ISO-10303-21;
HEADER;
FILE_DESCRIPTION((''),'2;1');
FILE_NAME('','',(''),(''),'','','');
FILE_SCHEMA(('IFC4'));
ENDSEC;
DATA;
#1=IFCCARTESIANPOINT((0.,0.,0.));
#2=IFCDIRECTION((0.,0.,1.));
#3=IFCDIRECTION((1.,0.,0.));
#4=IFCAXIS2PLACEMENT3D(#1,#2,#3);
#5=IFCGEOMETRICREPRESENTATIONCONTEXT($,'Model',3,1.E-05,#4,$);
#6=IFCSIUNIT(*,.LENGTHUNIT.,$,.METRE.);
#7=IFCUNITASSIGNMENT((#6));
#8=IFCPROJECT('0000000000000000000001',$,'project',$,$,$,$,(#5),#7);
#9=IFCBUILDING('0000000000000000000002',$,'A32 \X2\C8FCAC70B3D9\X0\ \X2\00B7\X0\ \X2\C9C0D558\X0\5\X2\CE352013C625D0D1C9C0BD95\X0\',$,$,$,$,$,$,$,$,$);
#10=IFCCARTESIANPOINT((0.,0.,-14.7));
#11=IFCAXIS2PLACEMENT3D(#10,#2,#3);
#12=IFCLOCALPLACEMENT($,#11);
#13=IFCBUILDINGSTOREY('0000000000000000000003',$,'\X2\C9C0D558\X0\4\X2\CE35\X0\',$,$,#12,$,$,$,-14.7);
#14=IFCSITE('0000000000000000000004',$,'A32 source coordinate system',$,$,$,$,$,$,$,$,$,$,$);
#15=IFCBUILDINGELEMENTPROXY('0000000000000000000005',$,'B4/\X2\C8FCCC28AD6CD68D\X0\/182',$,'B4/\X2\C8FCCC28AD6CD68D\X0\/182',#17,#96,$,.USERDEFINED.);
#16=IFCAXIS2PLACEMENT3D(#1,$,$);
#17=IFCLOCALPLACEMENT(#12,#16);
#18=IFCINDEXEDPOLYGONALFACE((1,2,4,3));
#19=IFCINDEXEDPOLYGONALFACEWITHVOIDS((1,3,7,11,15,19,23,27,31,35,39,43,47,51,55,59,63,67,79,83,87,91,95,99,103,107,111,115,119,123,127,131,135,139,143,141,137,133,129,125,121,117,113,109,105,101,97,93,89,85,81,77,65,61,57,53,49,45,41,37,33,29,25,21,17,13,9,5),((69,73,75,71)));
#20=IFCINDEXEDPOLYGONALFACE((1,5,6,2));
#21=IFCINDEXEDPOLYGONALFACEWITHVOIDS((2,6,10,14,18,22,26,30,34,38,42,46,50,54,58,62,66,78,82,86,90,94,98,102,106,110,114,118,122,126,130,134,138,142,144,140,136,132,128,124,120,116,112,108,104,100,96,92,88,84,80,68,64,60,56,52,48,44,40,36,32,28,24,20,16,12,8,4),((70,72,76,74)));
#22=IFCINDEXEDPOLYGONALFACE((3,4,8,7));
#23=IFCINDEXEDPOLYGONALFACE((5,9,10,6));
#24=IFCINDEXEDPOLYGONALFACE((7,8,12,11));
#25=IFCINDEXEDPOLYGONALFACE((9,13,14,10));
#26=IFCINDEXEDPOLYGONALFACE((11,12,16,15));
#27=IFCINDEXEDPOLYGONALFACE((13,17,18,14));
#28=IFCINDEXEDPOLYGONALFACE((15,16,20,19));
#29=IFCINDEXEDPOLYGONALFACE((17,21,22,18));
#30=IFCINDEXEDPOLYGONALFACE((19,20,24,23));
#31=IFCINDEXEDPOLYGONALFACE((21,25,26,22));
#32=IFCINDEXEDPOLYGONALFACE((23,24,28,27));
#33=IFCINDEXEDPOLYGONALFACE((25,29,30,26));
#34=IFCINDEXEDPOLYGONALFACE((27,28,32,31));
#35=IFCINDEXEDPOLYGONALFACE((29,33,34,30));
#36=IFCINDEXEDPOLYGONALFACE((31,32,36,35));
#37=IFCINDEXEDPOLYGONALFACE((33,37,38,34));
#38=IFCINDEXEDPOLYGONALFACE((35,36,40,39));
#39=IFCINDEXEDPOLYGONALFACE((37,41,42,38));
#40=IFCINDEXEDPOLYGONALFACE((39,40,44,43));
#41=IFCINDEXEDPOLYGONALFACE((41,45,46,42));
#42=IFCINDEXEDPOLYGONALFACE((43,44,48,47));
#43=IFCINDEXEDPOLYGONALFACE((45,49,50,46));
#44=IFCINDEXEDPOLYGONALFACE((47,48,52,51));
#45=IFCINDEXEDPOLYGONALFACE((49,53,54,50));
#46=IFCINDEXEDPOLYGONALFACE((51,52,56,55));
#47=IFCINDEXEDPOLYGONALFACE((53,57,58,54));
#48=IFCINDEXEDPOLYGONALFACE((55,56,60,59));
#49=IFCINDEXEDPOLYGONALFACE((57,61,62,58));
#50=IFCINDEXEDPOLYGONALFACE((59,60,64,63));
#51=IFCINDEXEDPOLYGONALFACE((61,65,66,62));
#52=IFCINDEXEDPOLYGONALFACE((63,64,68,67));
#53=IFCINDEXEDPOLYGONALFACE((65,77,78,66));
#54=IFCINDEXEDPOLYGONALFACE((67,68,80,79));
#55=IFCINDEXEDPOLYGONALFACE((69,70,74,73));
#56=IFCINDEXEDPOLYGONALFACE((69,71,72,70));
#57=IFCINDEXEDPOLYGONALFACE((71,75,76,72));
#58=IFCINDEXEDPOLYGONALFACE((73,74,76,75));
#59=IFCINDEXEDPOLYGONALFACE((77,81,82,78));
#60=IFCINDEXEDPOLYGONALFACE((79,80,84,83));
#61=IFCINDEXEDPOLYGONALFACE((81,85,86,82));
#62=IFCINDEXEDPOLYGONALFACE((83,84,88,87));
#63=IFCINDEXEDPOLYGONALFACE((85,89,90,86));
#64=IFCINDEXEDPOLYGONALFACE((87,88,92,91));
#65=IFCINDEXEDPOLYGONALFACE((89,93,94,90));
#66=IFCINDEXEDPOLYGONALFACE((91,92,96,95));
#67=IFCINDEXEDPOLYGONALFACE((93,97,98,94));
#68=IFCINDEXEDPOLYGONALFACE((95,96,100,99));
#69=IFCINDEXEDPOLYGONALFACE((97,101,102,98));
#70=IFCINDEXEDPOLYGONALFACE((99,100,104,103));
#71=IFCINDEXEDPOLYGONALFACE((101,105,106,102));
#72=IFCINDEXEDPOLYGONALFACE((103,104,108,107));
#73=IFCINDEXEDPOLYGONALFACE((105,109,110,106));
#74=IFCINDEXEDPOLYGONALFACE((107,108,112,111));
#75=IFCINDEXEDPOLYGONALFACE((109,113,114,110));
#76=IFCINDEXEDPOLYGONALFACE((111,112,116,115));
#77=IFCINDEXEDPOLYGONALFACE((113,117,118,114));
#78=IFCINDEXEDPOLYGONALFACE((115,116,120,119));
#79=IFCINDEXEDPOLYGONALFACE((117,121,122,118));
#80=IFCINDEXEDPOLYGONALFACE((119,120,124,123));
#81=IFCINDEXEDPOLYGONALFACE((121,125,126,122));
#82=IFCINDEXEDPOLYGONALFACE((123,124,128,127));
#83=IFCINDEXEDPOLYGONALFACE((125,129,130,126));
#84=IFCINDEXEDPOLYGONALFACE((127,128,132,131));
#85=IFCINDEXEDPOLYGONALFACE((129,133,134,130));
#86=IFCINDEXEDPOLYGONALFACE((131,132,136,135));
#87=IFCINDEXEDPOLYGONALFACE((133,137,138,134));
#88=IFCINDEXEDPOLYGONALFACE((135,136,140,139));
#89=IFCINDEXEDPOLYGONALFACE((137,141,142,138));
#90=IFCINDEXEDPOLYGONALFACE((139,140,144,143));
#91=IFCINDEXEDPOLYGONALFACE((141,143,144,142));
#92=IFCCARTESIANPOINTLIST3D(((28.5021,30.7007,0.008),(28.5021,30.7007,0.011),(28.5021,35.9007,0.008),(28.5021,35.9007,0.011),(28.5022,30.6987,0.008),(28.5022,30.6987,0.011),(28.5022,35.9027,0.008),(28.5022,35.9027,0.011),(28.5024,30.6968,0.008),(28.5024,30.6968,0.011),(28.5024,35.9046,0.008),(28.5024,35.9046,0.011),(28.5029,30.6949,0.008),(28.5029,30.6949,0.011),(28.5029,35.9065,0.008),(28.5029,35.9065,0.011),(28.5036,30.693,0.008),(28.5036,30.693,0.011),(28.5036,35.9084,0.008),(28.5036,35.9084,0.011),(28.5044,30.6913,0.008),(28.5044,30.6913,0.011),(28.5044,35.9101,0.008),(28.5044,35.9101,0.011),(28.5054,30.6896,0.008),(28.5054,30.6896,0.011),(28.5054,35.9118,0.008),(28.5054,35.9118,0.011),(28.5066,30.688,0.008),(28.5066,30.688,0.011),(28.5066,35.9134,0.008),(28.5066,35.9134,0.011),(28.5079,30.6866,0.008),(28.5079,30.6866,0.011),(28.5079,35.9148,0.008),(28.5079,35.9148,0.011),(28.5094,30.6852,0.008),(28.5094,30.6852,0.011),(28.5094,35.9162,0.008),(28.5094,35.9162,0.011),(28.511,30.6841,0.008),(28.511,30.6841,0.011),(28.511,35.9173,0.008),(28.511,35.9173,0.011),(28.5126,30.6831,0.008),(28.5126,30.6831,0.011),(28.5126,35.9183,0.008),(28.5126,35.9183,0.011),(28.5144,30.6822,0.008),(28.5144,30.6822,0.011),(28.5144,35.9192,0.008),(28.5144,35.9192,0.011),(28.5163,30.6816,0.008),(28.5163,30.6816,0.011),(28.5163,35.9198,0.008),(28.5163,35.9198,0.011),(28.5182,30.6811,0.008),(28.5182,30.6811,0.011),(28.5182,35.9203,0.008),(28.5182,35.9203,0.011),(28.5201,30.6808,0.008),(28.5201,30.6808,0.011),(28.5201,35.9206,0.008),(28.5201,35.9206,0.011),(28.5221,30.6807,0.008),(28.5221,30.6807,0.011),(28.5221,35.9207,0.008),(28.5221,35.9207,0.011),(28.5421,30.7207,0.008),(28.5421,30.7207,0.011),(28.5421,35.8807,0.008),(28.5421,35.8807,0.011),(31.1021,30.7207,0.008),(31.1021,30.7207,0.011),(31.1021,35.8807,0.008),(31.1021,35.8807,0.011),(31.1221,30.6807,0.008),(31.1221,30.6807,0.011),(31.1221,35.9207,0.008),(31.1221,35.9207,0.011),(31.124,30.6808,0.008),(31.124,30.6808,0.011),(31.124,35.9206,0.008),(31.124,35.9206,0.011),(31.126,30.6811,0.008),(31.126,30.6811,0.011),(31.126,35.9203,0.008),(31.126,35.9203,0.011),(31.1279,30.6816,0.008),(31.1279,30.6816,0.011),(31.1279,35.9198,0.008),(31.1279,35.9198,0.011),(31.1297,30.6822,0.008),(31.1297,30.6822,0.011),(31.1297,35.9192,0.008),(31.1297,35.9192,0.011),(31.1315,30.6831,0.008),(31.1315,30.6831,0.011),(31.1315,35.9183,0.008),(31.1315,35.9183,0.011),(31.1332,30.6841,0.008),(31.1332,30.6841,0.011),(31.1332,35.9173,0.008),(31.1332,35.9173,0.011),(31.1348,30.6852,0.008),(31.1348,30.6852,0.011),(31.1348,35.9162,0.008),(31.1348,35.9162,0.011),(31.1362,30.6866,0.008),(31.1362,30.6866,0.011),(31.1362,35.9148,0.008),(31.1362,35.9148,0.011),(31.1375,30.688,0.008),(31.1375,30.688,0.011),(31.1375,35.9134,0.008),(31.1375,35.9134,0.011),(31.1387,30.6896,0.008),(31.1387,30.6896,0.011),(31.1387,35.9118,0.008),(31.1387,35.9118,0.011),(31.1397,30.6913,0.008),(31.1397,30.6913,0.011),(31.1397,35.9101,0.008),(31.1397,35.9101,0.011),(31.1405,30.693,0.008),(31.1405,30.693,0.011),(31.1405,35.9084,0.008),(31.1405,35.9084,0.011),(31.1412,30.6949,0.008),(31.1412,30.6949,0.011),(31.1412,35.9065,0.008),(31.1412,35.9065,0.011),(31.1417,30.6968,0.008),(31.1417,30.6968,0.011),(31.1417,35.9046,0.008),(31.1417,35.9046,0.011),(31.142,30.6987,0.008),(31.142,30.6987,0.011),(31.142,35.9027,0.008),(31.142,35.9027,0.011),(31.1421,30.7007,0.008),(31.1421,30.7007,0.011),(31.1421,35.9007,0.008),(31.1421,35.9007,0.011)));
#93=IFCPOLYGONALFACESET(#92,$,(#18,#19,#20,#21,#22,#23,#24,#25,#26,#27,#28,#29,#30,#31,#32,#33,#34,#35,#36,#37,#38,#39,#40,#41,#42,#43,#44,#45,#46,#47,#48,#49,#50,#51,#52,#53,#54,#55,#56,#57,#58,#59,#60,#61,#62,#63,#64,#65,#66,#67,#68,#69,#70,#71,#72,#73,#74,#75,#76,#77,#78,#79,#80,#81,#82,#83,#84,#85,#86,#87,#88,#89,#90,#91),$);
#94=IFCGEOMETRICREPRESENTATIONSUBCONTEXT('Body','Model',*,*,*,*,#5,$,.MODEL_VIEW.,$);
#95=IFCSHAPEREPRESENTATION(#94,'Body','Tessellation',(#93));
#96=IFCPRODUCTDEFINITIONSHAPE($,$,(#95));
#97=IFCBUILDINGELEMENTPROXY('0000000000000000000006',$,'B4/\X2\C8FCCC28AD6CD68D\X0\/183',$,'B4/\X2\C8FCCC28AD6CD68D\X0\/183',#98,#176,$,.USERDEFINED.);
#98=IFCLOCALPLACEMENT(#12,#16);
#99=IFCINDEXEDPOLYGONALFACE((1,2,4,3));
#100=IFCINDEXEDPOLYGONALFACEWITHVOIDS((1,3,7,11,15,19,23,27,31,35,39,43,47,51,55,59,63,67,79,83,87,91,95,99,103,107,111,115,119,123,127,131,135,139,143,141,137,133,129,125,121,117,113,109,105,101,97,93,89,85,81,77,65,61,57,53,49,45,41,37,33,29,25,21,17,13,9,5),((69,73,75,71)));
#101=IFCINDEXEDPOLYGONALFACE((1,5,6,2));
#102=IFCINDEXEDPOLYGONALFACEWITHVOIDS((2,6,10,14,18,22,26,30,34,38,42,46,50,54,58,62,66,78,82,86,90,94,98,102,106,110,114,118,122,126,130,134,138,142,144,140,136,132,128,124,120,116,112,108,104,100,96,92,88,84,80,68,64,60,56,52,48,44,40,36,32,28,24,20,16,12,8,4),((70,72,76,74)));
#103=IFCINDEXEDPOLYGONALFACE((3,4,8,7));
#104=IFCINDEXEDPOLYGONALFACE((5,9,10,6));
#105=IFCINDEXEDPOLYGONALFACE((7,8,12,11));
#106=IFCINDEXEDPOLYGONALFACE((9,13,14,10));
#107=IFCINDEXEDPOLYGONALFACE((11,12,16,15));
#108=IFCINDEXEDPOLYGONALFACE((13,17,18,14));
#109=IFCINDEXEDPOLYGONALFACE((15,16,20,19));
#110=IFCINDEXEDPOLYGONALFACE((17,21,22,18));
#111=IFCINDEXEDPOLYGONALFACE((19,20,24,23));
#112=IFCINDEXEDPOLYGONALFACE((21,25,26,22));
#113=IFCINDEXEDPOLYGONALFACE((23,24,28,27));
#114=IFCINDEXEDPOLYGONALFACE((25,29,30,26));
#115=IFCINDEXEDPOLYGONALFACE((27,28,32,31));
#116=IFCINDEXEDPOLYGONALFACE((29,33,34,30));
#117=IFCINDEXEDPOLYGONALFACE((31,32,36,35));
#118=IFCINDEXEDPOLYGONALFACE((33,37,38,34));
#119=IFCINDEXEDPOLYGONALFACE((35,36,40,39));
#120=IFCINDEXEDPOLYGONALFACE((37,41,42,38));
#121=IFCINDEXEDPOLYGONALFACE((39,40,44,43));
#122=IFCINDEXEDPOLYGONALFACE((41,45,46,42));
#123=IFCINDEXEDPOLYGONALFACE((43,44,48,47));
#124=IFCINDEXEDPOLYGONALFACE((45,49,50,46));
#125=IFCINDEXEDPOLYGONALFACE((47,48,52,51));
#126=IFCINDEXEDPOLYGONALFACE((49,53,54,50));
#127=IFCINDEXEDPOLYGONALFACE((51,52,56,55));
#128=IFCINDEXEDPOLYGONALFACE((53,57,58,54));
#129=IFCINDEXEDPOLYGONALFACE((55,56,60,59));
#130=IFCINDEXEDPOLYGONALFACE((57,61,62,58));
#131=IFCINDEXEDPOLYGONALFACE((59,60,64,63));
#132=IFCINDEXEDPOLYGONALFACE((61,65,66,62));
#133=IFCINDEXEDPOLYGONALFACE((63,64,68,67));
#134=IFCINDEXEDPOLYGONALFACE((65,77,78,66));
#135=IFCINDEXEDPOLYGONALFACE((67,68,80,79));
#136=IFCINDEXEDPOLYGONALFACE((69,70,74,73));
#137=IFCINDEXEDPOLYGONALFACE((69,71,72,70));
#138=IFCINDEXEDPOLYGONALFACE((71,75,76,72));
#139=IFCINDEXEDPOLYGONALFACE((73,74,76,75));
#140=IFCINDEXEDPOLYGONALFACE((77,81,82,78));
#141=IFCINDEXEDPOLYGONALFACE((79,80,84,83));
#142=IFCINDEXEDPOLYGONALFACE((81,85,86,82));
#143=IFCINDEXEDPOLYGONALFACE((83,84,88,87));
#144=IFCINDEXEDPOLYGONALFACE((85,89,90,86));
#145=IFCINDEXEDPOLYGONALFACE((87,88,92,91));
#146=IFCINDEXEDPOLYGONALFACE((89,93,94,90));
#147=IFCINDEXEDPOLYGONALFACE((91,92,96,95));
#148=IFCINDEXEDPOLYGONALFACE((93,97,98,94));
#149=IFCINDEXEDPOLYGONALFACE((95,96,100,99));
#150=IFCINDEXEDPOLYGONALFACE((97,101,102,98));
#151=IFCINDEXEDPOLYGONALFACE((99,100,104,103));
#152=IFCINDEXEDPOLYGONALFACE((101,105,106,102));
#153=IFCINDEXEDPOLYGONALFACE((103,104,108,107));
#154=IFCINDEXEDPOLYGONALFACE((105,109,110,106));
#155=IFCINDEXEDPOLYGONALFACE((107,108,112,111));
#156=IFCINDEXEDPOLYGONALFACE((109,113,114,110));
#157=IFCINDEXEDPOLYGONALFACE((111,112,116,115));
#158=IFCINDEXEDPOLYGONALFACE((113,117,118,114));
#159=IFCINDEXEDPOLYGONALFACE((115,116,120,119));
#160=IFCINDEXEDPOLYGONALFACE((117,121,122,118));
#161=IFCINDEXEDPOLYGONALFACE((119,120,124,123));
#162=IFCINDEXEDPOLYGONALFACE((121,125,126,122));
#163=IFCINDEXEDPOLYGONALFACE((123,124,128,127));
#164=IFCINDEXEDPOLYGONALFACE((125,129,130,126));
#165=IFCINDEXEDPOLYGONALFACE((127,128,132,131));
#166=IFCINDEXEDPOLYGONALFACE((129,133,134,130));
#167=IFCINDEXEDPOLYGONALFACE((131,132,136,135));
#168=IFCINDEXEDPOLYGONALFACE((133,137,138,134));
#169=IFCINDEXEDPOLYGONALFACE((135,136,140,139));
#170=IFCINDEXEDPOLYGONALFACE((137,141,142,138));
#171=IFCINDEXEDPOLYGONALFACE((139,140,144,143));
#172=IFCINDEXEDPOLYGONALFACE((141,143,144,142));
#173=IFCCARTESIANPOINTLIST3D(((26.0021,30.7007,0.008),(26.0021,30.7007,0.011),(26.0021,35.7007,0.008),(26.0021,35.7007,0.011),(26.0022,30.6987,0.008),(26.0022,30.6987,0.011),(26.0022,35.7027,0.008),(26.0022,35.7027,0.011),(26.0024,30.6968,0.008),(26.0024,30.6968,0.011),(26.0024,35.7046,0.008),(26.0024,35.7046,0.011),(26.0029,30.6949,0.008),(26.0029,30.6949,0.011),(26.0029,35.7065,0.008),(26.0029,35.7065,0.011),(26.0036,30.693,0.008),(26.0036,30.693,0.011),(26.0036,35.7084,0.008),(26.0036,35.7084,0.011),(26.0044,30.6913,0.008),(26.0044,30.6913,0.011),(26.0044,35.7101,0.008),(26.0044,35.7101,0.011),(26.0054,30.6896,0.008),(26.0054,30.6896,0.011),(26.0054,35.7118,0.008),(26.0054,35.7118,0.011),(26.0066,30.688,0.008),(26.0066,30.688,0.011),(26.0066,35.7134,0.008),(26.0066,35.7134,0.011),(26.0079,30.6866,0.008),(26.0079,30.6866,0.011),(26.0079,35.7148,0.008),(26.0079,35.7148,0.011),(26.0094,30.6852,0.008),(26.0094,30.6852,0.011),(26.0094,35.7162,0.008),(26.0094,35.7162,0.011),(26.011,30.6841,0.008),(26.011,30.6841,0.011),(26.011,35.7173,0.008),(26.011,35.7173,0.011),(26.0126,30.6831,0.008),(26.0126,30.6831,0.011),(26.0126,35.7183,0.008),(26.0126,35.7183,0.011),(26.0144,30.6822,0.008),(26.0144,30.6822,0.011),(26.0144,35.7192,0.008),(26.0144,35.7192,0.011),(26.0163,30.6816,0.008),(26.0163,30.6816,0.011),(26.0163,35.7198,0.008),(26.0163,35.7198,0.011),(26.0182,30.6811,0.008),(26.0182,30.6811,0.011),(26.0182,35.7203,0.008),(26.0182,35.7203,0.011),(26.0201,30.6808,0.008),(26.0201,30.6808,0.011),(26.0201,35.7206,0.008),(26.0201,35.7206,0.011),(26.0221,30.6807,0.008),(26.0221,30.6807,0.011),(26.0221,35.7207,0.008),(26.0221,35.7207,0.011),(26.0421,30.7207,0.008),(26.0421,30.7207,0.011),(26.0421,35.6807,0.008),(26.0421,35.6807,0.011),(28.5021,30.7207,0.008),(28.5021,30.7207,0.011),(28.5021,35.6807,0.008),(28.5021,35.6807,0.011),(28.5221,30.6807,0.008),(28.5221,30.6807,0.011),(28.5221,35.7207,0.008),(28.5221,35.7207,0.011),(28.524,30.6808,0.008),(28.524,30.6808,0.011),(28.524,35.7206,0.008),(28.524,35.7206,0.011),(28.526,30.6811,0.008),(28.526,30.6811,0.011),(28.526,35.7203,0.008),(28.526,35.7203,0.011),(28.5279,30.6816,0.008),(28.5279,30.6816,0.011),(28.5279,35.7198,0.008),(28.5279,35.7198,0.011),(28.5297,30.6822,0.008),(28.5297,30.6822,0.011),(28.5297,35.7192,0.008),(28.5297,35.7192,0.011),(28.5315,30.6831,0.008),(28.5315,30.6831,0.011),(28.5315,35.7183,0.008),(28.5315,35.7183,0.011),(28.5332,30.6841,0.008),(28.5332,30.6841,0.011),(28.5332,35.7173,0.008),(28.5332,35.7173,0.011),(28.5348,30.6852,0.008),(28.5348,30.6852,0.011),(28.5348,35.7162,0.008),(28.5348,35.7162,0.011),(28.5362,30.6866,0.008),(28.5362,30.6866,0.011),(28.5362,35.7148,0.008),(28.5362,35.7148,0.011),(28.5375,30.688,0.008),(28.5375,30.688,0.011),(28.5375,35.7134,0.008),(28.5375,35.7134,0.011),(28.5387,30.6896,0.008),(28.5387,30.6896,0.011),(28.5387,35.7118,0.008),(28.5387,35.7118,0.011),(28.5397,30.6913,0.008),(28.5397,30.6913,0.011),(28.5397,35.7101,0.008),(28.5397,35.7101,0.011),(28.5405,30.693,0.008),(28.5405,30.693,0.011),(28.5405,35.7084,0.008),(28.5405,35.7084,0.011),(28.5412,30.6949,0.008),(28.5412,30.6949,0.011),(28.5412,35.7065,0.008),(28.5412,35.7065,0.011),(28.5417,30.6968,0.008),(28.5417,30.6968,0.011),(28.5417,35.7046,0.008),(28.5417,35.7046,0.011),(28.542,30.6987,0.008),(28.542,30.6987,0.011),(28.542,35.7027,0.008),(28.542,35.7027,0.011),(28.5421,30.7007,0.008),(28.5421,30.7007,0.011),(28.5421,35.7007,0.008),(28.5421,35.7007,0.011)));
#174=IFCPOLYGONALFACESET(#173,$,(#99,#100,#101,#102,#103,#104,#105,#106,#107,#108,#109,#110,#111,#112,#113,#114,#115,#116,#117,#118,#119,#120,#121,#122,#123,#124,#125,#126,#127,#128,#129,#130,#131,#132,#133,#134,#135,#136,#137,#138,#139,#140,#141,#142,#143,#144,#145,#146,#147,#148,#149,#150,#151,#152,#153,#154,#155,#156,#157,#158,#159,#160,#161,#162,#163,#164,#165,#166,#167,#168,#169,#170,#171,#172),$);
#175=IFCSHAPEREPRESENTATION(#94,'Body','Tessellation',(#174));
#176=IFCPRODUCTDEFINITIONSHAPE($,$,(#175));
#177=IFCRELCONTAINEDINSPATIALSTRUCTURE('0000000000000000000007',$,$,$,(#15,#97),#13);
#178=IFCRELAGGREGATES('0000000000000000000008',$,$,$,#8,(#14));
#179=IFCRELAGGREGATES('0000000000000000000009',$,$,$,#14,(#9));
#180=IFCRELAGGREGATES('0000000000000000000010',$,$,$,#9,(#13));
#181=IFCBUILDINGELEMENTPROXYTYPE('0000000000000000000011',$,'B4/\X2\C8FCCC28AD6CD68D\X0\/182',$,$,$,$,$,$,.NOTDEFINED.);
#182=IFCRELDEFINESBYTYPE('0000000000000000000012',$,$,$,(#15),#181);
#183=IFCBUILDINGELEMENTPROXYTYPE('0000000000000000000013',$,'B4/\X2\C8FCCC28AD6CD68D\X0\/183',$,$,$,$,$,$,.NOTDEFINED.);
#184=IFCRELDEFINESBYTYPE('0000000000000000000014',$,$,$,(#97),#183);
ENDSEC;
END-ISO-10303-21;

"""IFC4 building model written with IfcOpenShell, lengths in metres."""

from ifc_helpers import new_model, si_unit, frame, origin, origin_with_axes, place, context, subcontext, project, spatial, polyline, outline, extrude, source, transform, mapped, type_object, type_shapes, element, save


model = new_model("IFC4")

# Units and contexts
model_context = context("Model", 3, precision=1e-05, world=origin_with_axes())
body_context = subcontext(model_context, "Body", "Model", "MODEL_VIEW")
ifc_project = project(units=[si_unit("LENGTHUNIT", "METRE")], contexts=[model_context])

# Site, building, storey
site = spatial("IfcSite", under=ifc_project, Name="A32 source coordinate system")
building = spatial("IfcBuilding", under=site, Name="A32 주거동 · 지하5층–옥탑지붕")
storey_placement = place(None, frame((0.0, 0.0, -14.7), z_axis=(0.0, 0.0, 1.0), x_axis=(1.0, 0.0, 0.0)))
storey = spatial("IfcBuildingStorey", under=building, at=storey_placement, Name="지하4층", Elevation=-14.7)

# Building element proxies
building_element_proxy_type_1 = type_object("IfcBuildingElementProxyType", Name="B4/주차구획/182", PredefinedType="NOTDEFINED")
shared_shape_1 = source(origin(), body_context, "Body", "SweptSolid", [
    extrude(outline(polyline([(28.5021, 35.9007), (28.5022, 35.9027), (28.5024, 35.9046), (28.5029, 35.9065), (28.5036, 35.9084), (28.5044, 35.9101), (28.5054, 35.9118), (28.5066, 35.9134), (28.5079, 35.9148), (28.5094, 35.9162), (28.511, 35.9173), (28.5126, 35.9183), (28.5144, 35.9192), (28.5163, 35.9198), (28.5182, 35.9203), (28.5201, 35.9206), (28.5221, 35.9207), (31.1221, 35.9207), (31.124, 35.9206), (31.126, 35.9203), (31.1279, 35.9198), (31.1297, 35.9192), (31.1315, 35.9183), (31.1332, 35.9173), (31.1348, 35.9162), (31.1362, 35.9148), (31.1375, 35.9134), (31.1387, 35.9118), (31.1397, 35.9101), (31.1405, 35.9084), (31.1412, 35.9065), (31.1417, 35.9046), (31.142, 35.9027), (31.1421, 35.9007), (31.1421, 30.7007), (31.142, 30.6987), (31.1417, 30.6968), (31.1412, 30.6949), (31.1405, 30.693), (31.1397, 30.6913), (31.1387, 30.6896), (31.1375, 30.688), (31.1362, 30.6866), (31.1348, 30.6852), (31.1332, 30.6841), (31.1315, 30.6831), (31.1297, 30.6822), (31.1279, 30.6816), (31.126, 30.6811), (31.124, 30.6808), (31.1221, 30.6807), (28.5221, 30.6807), (28.5201, 30.6808), (28.5182, 30.6811), (28.5163, 30.6816), (28.5144, 30.6822), (28.5126, 30.6831), (28.511, 30.6841), (28.5094, 30.6852), (28.5079, 30.6866), (28.5066, 30.688), (28.5054, 30.6896), (28.5044, 30.6913), (28.5036, 30.693), (28.5029, 30.6949), (28.5024, 30.6968), (28.5022, 30.6987), (28.5021, 30.7007), (28.5021, 35.9007)]), holes=[polyline([(28.5421, 35.8807), (28.5421, 30.7207), (31.1021, 30.7207), (31.1021, 35.8807), (28.5421, 35.8807)])]), frame((0.0, 0.0, 0.008)), (0.0, 0.0, 1.0), 0.003),
])
type_shapes(building_element_proxy_type_1, [shared_shape_1])
proxy_1_placement = place(storey_placement, origin_with_axes())
element("IfcBuildingElementProxy", 1, at=proxy_1_placement, inside=storey, type_object=building_element_proxy_type_1, Name="B4/주차구획/182", ObjectType="B4/주차구획/182", PredefinedType="USERDEFINED", context=body_context, shape_type="MappedRepresentation", body=[
    mapped(shared_shape_1, transform((0.0, 0.0, 0.0), scale=1.0)),
])
building_element_proxy_type_2 = type_object("IfcBuildingElementProxyType", Name="B4/주차구획/183", PredefinedType="NOTDEFINED")
shared_shape_2 = source(origin(), body_context, "Body", "SweptSolid", [
    extrude(outline(polyline([(26.0021, 35.7007), (26.0022, 35.7027), (26.0024, 35.7046), (26.0029, 35.7065), (26.0036, 35.7084), (26.0044, 35.7101), (26.0054, 35.7118), (26.0066, 35.7134), (26.0079, 35.7148), (26.0094, 35.7162), (26.011, 35.7173), (26.0126, 35.7183), (26.0144, 35.7192), (26.0163, 35.7198), (26.0182, 35.7203), (26.0201, 35.7206), (26.0221, 35.7207), (28.5221, 35.7207), (28.524, 35.7206), (28.526, 35.7203), (28.5279, 35.7198), (28.5297, 35.7192), (28.5315, 35.7183), (28.5332, 35.7173), (28.5348, 35.7162), (28.5362, 35.7148), (28.5375, 35.7134), (28.5387, 35.7118), (28.5397, 35.7101), (28.5405, 35.7084), (28.5412, 35.7065), (28.5417, 35.7046), (28.542, 35.7027), (28.5421, 35.7007), (28.5421, 30.7007), (28.542, 30.6987), (28.5417, 30.6968), (28.5412, 30.6949), (28.5405, 30.693), (28.5397, 30.6913), (28.5387, 30.6896), (28.5375, 30.688), (28.5362, 30.6866), (28.5348, 30.6852), (28.5332, 30.6841), (28.5315, 30.6831), (28.5297, 30.6822), (28.5279, 30.6816), (28.526, 30.6811), (28.524, 30.6808), (28.5221, 30.6807), (26.0221, 30.6807), (26.0201, 30.6808), (26.0182, 30.6811), (26.0163, 30.6816), (26.0144, 30.6822), (26.0126, 30.6831), (26.011, 30.6841), (26.0094, 30.6852), (26.0079, 30.6866), (26.0066, 30.688), (26.0054, 30.6896), (26.0044, 30.6913), (26.0036, 30.693), (26.0029, 30.6949), (26.0024, 30.6968), (26.0022, 30.6987), (26.0021, 30.7007), (26.0021, 35.7007)]), holes=[polyline([(26.0421, 35.6807), (26.0421, 30.7207), (28.5021, 30.7207), (28.5021, 35.6807), (26.0421, 35.6807)])]), frame((0.0, 0.0, 0.008)), (0.0, 0.0, 1.0), 0.003),
])
type_shapes(building_element_proxy_type_2, [shared_shape_2])
proxy_2_placement = place(storey_placement, origin_with_axes())
element("IfcBuildingElementProxy", 2, at=proxy_2_placement, inside=storey, type_object=building_element_proxy_type_2, Name="B4/주차구획/183", ObjectType="B4/주차구획/183", PredefinedType="USERDEFINED", context=body_context, shape_type="MappedRepresentation", body=[
    mapped(shared_shape_2, transform((0.0, 0.0, 0.0), scale=1.0)),
])

save(model, "model.ifc")
